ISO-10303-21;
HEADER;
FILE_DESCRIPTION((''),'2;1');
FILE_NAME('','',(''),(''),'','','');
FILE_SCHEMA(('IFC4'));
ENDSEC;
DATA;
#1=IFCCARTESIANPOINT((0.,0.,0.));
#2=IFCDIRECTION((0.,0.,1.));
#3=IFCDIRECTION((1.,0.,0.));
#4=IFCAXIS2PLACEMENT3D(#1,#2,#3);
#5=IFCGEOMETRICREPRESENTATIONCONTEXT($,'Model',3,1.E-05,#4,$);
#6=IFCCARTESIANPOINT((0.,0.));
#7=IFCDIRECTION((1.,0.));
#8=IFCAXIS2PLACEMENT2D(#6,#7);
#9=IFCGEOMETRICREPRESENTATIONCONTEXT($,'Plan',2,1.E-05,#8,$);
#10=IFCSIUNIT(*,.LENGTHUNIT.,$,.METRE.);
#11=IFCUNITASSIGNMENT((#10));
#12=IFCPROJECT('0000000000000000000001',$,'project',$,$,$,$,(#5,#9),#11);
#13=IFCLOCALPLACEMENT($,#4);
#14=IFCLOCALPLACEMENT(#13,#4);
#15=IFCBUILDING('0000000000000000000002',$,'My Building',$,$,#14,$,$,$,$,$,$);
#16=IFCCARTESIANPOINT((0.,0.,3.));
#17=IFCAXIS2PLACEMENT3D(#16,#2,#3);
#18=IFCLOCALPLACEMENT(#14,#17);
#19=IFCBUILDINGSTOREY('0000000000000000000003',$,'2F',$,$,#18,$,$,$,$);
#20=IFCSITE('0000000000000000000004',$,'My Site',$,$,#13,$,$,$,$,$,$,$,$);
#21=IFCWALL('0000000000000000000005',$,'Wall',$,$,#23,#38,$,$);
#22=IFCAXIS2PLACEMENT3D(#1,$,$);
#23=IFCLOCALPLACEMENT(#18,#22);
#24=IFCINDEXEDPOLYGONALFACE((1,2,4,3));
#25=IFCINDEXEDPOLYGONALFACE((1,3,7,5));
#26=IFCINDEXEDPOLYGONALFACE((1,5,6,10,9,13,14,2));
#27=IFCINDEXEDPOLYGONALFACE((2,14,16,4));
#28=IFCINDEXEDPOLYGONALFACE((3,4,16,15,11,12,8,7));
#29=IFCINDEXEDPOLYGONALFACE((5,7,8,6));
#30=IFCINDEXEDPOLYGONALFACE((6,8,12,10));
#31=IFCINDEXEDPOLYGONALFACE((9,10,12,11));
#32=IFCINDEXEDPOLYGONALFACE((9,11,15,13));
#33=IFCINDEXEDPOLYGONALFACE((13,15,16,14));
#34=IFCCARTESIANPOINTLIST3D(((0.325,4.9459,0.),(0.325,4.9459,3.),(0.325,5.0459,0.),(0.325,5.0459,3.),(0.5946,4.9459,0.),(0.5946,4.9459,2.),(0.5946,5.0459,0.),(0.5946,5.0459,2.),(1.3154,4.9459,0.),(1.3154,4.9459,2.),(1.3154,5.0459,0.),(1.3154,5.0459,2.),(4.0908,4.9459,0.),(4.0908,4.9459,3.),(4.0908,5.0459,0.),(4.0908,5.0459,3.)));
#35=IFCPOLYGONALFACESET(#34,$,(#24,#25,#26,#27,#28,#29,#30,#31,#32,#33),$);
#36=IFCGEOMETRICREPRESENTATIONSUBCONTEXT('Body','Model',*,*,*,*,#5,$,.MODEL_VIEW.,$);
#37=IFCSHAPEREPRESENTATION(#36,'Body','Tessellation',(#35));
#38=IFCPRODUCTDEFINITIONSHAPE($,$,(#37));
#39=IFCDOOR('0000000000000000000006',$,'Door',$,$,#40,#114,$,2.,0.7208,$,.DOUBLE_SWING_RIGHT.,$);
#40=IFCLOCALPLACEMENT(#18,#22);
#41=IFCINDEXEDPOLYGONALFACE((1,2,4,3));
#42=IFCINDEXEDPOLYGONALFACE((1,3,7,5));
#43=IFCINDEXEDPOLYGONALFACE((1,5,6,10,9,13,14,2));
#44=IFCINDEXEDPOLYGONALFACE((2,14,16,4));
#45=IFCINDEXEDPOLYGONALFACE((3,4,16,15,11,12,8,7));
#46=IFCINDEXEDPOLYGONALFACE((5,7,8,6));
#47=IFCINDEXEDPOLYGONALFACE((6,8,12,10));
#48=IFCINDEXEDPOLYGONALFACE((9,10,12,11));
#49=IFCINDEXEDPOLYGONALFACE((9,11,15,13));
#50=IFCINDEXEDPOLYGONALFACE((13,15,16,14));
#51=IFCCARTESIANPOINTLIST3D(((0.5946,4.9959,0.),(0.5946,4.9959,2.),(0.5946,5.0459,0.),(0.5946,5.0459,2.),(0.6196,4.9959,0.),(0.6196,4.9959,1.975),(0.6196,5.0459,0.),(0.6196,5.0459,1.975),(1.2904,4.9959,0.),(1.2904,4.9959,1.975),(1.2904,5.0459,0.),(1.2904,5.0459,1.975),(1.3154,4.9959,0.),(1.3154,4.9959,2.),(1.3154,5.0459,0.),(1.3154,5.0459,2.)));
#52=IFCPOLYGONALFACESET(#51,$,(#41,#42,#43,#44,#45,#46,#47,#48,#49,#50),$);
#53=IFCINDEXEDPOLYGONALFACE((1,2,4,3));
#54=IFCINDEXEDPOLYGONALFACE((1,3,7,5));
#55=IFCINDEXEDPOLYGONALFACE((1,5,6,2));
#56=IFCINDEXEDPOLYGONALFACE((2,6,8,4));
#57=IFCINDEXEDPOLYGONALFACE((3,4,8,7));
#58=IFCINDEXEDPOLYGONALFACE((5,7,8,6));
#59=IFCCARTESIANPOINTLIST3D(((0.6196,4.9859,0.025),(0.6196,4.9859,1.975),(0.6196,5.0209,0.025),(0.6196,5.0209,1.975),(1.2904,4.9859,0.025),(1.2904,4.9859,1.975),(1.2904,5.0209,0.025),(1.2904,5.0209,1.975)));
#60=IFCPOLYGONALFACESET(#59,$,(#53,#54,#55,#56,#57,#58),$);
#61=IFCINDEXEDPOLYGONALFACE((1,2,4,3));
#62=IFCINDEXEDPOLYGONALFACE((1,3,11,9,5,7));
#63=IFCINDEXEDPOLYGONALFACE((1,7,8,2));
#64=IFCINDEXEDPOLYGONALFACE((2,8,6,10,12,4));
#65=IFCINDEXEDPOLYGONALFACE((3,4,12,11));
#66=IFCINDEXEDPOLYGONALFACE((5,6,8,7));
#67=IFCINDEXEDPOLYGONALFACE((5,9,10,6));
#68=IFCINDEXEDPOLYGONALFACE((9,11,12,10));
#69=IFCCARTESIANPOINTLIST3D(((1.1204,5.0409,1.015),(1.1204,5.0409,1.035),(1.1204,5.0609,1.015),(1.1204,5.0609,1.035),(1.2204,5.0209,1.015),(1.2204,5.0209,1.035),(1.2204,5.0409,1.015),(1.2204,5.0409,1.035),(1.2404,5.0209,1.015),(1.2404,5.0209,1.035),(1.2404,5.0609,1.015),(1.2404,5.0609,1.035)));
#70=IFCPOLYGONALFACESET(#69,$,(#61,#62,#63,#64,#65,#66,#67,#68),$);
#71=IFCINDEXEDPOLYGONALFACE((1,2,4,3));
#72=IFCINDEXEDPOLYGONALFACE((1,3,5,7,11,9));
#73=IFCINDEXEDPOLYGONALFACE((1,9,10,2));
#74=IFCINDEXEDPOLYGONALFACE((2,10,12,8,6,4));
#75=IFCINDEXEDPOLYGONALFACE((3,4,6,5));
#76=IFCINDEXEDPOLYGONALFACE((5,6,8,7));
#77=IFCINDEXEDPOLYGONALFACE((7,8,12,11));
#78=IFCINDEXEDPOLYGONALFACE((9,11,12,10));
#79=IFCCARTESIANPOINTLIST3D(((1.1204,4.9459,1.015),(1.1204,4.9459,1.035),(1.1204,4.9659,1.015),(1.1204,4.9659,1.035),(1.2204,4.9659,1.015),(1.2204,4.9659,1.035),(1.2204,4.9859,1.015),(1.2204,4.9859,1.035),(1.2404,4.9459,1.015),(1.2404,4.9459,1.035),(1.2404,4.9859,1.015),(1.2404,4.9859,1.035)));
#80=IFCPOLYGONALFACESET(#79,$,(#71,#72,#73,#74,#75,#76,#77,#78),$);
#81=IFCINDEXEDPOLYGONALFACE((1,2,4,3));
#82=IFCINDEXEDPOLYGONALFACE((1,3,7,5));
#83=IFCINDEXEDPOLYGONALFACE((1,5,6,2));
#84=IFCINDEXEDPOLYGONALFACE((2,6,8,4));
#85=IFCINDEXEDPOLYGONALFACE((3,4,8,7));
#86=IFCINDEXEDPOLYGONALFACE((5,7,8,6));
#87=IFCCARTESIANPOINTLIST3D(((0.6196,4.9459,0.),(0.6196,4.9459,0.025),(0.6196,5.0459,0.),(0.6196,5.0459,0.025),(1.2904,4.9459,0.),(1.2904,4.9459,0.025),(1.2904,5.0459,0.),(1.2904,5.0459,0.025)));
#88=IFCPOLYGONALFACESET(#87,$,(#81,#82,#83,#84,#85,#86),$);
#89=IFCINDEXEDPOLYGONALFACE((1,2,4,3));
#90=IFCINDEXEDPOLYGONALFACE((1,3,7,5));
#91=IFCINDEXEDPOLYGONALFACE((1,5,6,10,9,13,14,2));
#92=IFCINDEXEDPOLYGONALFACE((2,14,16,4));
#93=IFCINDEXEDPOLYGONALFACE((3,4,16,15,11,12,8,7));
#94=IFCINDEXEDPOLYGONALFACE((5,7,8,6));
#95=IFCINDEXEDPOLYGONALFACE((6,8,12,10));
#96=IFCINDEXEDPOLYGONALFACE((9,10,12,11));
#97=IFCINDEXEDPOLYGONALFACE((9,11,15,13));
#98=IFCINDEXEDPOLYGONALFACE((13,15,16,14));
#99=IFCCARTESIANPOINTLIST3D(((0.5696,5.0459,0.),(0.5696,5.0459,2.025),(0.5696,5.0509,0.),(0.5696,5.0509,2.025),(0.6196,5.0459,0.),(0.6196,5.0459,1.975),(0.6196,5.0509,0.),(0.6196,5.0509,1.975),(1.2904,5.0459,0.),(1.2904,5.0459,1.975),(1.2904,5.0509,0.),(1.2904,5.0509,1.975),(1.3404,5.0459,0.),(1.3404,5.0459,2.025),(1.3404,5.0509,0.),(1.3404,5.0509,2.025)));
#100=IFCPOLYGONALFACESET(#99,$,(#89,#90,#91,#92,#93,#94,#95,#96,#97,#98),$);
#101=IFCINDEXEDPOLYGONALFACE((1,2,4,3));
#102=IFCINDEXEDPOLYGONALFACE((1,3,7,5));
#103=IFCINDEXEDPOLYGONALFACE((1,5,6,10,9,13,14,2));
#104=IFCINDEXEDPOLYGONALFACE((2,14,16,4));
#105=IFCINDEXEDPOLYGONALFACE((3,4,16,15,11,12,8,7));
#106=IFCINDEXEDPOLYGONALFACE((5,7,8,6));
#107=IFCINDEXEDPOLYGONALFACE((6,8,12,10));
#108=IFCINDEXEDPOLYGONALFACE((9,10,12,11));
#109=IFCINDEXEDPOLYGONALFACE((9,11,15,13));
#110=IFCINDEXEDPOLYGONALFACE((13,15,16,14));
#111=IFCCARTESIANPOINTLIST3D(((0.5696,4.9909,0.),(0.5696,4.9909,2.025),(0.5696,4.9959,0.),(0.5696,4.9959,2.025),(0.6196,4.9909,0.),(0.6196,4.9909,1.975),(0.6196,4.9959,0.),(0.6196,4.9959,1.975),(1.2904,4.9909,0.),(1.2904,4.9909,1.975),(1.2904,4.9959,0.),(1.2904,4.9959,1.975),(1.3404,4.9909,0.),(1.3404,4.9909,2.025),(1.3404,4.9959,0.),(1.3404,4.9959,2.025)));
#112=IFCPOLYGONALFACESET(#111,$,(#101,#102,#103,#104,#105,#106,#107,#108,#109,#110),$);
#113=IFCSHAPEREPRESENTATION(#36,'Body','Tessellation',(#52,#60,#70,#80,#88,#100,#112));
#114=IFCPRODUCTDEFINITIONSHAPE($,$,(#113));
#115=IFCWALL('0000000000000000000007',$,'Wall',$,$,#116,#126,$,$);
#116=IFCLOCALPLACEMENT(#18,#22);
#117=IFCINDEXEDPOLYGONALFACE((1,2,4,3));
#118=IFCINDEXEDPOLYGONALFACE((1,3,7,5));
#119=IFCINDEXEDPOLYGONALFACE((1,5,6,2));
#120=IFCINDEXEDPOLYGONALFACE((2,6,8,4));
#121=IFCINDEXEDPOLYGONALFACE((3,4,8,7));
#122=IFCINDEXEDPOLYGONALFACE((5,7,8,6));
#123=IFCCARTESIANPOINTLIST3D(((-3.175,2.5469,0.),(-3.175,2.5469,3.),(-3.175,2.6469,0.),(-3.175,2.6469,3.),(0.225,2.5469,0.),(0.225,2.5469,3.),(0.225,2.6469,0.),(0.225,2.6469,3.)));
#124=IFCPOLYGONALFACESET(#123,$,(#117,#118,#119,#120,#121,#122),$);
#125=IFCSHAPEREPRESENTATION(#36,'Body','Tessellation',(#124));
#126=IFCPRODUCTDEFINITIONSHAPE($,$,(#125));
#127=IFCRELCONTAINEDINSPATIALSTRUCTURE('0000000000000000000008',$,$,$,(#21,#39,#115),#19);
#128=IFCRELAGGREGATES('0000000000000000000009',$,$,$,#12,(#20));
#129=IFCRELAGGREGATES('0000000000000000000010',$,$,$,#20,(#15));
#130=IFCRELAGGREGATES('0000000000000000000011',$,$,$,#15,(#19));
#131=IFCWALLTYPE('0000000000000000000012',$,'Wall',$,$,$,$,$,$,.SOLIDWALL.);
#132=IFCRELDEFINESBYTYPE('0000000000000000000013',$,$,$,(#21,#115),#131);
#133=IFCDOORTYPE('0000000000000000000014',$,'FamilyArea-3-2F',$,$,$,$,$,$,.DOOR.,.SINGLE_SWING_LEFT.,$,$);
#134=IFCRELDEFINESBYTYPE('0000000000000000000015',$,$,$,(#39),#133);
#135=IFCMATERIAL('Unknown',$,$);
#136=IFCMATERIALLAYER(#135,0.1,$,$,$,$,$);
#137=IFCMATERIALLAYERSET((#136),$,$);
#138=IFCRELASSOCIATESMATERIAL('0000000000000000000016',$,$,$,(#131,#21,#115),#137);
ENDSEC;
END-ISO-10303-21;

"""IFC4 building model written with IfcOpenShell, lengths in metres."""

from ifc_helpers import new_model, entity, si_unit, frame, origin_with_axes, origin_2d_with_axis, place, context, subcontext, project, spatial, line, indexed_curve, outline, extrude, shape, source, transform, mapped, material, layer, layer_set, layer_usage, type_object, type_shapes, element, fill, save


model = new_model("IFC4")

# Units and contexts
model_context = context("Model", 3, precision=1e-05, world=origin_with_axes())
plan_context = context("Plan", 2, precision=1e-05, world=origin_2d_with_axis())
body_context_1 = subcontext(model_context, "Body", "Model", "MODEL_VIEW")
body_context_2 = subcontext(plan_context, "Body", "Plan", "PLAN_VIEW")
ifc_project = project(units=[si_unit("LENGTHUNIT", "METRE")], contexts=[model_context, plan_context])

# Site, building, storey
site_placement = place(None, origin_with_axes())
site = spatial("IfcSite", under=ifc_project, at=site_placement, Name="My Site")
building_placement = place(site_placement, origin_with_axes())
building = spatial("IfcBuilding", under=site, at=building_placement, Name="My Building")
storey_placement = place(building_placement, frame((0.0, 0.0, 3.0), z_axis=(0.0, 0.0, 1.0), x_axis=(1.0, 0.0, 0.0)))
storey = spatial("IfcBuildingStorey", under=building, at=storey_placement, Name="2F")

# Shared definitions
ifc_material = material(Name="Unknown")

# Shared definitions
ifc_layer_1 = layer(ifc_material, 0.1)
ifc_layer_set_1 = layer_set([ifc_layer_1])
wall_type = type_object("IfcWallType", Name="Wall", PredefinedType="SOLIDWALL", material=ifc_layer_set_1)

# Wall, opening, door
ifc_layer_usage_1 = layer_usage(ifc_layer_set_1, "AXIS2", "POSITIVE", 0.0)
wall_1_placement = place(storey_placement, frame((4.0908, 5.0459, 0.0), z_axis=(0.0, 0.0, 1.0), x_axis=(-1.0, 0.0, 0.0)))
wall_1 = element("IfcWall", 1, at=wall_1_placement, inside=storey, type_object=wall_type, material=ifc_layer_usage_1, Name="Wall", context=body_context_1, shape_type="SweptSolid", body=[
    extrude(outline(indexed_curve([(0.0, 0.0), (0.0, 0.1), (3.7659, 0.1), (3.7659, 0.0)], segments=[line(1, 2, 3, 4, 1)])), origin_with_axes(), (0.0, 0.0, 1.0), 3.0),
])
shared_shape_1 = source(origin_with_axes(), body_context_1, "Body", "SweptSolid", [
    extrude(outline(indexed_curve([(0.0, 0.0), (0.7208, 0.0), (0.7208, 2.0), (0.0, 2.0)], segments=[line(1, 2, 3, 4, 1)])), frame((0.0, -0.6, 0.0), z_axis=(0.0, -1.0, 0.0), x_axis=(1.0, 0.0, 0.0)), (0.0, 0.0, -1.0), 1.2),
])
opening_1_placement = place(wall_1_placement, frame((2.7755, 0.0, 0.0), z_axis=(0.0, 0.0, 1.0), x_axis=(1.0, 0.0, 0.0)))
opening_1 = element("IfcOpeningElement", 2, at=opening_1_placement, cuts=wall_1, PredefinedType="OPENING", context=body_context_1, shape_type="MappedRepresentation", body=[
    mapped(shared_shape_1, transform((0.0, 0.0, 0.0), x_axis=(1.0, 0.0, 0.0), y_axis=(0.0, 1.0, 0.0), z_axis=(0.0, 0.0, 1.0), scale=1.0)),
])
door_type_1 = type_object("IfcDoorType", Name="FamilyArea-3-2F", OperationType="SINGLE_SWING_LEFT", PredefinedType="DOOR")
shared_shape_2 = source(origin_with_axes(), body_context_1, "Body", "SweptSolid", [
    extrude(outline(indexed_curve([(0.0, 0.0), (0.0, 2.0), (0.7208, 2.0), (0.7208, 0.0), (0.6958, 0.0), (0.6958, 1.975), (0.025, 1.975), (0.025, 0.0)], segments=[line(1, 2, 3, 4, 5, 6, 7, 8, 1)])), frame((0.0, 0.0, 0.0), z_axis=(0.0, -1.0, 0.0), x_axis=(1.0, 0.0, 0.0)), (0.0, 0.0, -1.0), 0.05),
    extrude(outline(indexed_curve([(0.0, 0.0), (0.6708, 0.0), (0.6708, 0.035), (0.0, 0.035)], segments=[line(1, 2, 3, 4, 1)])), frame((0.025, 0.025, 0.025), z_axis=(0.0, 0.0, 1.0), x_axis=(1.0, 0.0, 0.0)), (0.0, 0.0, 1.0), 1.95),
    extrude(outline(indexed_curve([(0.0, 0.0), (0.0, -0.04), (0.12, -0.04), (0.12, -0.02), (0.02, -0.02), (0.02, 0.0)], segments=[line(1, 2, 3, 4, 5, 6, 1)])), frame((0.075, 0.025, 1.015), z_axis=(0.0, 0.0, 1.0), x_axis=(1.0, 0.0, 0.0)), (0.0, 0.0, 1.0), 0.02),
    extrude(outline(indexed_curve([(0.0, 0.0), (0.0, 0.04), (0.12, 0.04), (0.12, 0.02), (0.02, 0.02), (0.02, 0.0)], segments=[line(1, 2, 3, 4, 5, 6, 1)])), frame((0.075, 0.06, 1.015), z_axis=(0.0, 0.0, 1.0), x_axis=(1.0, 0.0, 0.0)), (0.0, 0.0, 1.0), 0.02),
    extrude(outline(indexed_curve([(0.0, 0.0), (0.6708, 0.0), (0.6708, 0.1), (0.0, 0.1)], segments=[line(1, 2, 3, 4, 1)])), frame((0.025, 0.0, 0.0), z_axis=(0.0, 0.0, 1.0), x_axis=(1.0, 0.0, 0.0)), (0.0, 0.0, 1.0), 0.025),
    extrude(outline(indexed_curve([(0.0, 0.0), (0.0, 2.025), (0.7708, 2.025), (0.7708, 0.0), (0.7208, 0.0), (0.7208, 1.975), (0.05, 1.975), (0.05, 0.0)], segments=[line(1, 2, 3, 4, 5, 6, 7, 8, 1)])), frame((-0.025, -0.005, 0.0), z_axis=(0.0, -1.0, 0.0), x_axis=(1.0, 0.0, 0.0)), (0.0, 0.0, -1.0), 0.005),
    extrude(outline(indexed_curve([(0.0, 0.0), (0.0, 2.025), (0.7708, 2.025), (0.7708, 0.0), (0.7208, 0.0), (0.7208, 1.975), (0.05, 1.975), (0.05, 0.0)], segments=[line(1, 2, 3, 4, 5, 6, 7, 8, 1)])), frame((-0.025, 0.05, 0.0), z_axis=(0.0, -1.0, 0.0), x_axis=(1.0, 0.0, 0.0)), (0.0, 0.0, -1.0), 0.005),
])
shared_shape_3 = source(origin_with_axes(), body_context_2, "Body", "Curve2D", [
    entity("IfcIndexedPolyCurve", entity("IfcCartesianPointList2D", [[0.0, 0.0], [0.025, 0.0], [0.025, 0.05], [0.0, 0.05]]), [entity("IfcLineIndex", [1, 2, 3, 4, 1])]),
    entity("IfcIndexedPolyCurve", entity("IfcCartesianPointList2D", [[0.7208, 0.0], [0.6958, 0.0], [0.6958, 0.05], [0.7208, 0.05]]), [entity("IfcLineIndex", [1, 2, 3, 4, 1])]),
    entity("IfcIndexedPolyCurve", entity("IfcCartesianPointList2D", [[0.6958, 0.05], [0.6958, -0.6208], [0.6608, -0.6208]])),
    entity("IfcTrimmedCurve", entity("IfcEllipse", entity("IfcAxis2Placement2D", entity("IfcCartesianPoint", [0.6608, 0.05]), entity("IfcDirection", [1.0, 0.0])), 0.6358, 0.6708), [entity("IfcCartesianPoint", [0.6608, 0.7208])], [entity("IfcCartesianPoint", [0.6608, -0.6208])], True, "CARTESIAN"),
    entity("IfcIndexedPolyCurve", entity("IfcCartesianPointList2D", [[0.6958, 0.05], [0.6608, 0.05], [0.6608, 0.7208], [0.6958, 0.7208]]), [entity("IfcLineIndex", [1, 2, 3, 4, 1])]),
])
type_shapes(door_type_1, [shared_shape_2, shared_shape_3])
door_1_placement = place(opening_1_placement, frame((0.0, 0.0, 0.0), z_axis=(0.0, 0.0, 1.0), x_axis=(1.0, 0.0, 0.0)))
door_1 = element("IfcDoor", 3, at=door_1_placement, inside=storey, type_object=door_type_1, Name="Door", OperationType="DOUBLE_SWING_RIGHT", OverallHeight=2.0, OverallWidth=0.7208, shapes=[
    shape(body_context_1, "Body", "MappedRepresentation", [mapped(shared_shape_2, transform((0.0, 0.0, 0.0), x_axis=(1.0, 0.0, 0.0), y_axis=(0.0, 1.0, 0.0), z_axis=(0.0, 0.0, 1.0), scale=1.0))]),
    shape(body_context_2, "Body", "MappedRepresentation", [mapped(shared_shape_3, transform((0.0, 0.0, 0.0), x_axis=(1.0, 0.0, 0.0), y_axis=(0.0, 1.0, 0.0), z_axis=(0.0, 0.0, 1.0), scale=1.0))]),
])
fill(opening_1, door_1)

# Wall
ifc_layer_usage_2 = layer_usage(ifc_layer_set_1, "AXIS2", "POSITIVE", 0.0)
wall_2_placement = place(storey_placement, frame((-3.175, 2.5469, 0.0), z_axis=(0.0, 0.0, 1.0), x_axis=(1.0, 0.0, 0.0)))
element("IfcWall", 4, at=wall_2_placement, inside=storey, type_object=wall_type, material=ifc_layer_usage_2, Name="Wall", context=body_context_1, shape_type="SweptSolid", body=[
    extrude(outline(indexed_curve([(0.0, 0.0), (0.0, 0.1), (3.4, 0.1), (3.4, 0.0)], segments=[line(1, 2, 3, 4, 1)])), origin_with_axes(), (0.0, 0.0, 1.0), 3.0),
])

save(model, "model.ifc")
